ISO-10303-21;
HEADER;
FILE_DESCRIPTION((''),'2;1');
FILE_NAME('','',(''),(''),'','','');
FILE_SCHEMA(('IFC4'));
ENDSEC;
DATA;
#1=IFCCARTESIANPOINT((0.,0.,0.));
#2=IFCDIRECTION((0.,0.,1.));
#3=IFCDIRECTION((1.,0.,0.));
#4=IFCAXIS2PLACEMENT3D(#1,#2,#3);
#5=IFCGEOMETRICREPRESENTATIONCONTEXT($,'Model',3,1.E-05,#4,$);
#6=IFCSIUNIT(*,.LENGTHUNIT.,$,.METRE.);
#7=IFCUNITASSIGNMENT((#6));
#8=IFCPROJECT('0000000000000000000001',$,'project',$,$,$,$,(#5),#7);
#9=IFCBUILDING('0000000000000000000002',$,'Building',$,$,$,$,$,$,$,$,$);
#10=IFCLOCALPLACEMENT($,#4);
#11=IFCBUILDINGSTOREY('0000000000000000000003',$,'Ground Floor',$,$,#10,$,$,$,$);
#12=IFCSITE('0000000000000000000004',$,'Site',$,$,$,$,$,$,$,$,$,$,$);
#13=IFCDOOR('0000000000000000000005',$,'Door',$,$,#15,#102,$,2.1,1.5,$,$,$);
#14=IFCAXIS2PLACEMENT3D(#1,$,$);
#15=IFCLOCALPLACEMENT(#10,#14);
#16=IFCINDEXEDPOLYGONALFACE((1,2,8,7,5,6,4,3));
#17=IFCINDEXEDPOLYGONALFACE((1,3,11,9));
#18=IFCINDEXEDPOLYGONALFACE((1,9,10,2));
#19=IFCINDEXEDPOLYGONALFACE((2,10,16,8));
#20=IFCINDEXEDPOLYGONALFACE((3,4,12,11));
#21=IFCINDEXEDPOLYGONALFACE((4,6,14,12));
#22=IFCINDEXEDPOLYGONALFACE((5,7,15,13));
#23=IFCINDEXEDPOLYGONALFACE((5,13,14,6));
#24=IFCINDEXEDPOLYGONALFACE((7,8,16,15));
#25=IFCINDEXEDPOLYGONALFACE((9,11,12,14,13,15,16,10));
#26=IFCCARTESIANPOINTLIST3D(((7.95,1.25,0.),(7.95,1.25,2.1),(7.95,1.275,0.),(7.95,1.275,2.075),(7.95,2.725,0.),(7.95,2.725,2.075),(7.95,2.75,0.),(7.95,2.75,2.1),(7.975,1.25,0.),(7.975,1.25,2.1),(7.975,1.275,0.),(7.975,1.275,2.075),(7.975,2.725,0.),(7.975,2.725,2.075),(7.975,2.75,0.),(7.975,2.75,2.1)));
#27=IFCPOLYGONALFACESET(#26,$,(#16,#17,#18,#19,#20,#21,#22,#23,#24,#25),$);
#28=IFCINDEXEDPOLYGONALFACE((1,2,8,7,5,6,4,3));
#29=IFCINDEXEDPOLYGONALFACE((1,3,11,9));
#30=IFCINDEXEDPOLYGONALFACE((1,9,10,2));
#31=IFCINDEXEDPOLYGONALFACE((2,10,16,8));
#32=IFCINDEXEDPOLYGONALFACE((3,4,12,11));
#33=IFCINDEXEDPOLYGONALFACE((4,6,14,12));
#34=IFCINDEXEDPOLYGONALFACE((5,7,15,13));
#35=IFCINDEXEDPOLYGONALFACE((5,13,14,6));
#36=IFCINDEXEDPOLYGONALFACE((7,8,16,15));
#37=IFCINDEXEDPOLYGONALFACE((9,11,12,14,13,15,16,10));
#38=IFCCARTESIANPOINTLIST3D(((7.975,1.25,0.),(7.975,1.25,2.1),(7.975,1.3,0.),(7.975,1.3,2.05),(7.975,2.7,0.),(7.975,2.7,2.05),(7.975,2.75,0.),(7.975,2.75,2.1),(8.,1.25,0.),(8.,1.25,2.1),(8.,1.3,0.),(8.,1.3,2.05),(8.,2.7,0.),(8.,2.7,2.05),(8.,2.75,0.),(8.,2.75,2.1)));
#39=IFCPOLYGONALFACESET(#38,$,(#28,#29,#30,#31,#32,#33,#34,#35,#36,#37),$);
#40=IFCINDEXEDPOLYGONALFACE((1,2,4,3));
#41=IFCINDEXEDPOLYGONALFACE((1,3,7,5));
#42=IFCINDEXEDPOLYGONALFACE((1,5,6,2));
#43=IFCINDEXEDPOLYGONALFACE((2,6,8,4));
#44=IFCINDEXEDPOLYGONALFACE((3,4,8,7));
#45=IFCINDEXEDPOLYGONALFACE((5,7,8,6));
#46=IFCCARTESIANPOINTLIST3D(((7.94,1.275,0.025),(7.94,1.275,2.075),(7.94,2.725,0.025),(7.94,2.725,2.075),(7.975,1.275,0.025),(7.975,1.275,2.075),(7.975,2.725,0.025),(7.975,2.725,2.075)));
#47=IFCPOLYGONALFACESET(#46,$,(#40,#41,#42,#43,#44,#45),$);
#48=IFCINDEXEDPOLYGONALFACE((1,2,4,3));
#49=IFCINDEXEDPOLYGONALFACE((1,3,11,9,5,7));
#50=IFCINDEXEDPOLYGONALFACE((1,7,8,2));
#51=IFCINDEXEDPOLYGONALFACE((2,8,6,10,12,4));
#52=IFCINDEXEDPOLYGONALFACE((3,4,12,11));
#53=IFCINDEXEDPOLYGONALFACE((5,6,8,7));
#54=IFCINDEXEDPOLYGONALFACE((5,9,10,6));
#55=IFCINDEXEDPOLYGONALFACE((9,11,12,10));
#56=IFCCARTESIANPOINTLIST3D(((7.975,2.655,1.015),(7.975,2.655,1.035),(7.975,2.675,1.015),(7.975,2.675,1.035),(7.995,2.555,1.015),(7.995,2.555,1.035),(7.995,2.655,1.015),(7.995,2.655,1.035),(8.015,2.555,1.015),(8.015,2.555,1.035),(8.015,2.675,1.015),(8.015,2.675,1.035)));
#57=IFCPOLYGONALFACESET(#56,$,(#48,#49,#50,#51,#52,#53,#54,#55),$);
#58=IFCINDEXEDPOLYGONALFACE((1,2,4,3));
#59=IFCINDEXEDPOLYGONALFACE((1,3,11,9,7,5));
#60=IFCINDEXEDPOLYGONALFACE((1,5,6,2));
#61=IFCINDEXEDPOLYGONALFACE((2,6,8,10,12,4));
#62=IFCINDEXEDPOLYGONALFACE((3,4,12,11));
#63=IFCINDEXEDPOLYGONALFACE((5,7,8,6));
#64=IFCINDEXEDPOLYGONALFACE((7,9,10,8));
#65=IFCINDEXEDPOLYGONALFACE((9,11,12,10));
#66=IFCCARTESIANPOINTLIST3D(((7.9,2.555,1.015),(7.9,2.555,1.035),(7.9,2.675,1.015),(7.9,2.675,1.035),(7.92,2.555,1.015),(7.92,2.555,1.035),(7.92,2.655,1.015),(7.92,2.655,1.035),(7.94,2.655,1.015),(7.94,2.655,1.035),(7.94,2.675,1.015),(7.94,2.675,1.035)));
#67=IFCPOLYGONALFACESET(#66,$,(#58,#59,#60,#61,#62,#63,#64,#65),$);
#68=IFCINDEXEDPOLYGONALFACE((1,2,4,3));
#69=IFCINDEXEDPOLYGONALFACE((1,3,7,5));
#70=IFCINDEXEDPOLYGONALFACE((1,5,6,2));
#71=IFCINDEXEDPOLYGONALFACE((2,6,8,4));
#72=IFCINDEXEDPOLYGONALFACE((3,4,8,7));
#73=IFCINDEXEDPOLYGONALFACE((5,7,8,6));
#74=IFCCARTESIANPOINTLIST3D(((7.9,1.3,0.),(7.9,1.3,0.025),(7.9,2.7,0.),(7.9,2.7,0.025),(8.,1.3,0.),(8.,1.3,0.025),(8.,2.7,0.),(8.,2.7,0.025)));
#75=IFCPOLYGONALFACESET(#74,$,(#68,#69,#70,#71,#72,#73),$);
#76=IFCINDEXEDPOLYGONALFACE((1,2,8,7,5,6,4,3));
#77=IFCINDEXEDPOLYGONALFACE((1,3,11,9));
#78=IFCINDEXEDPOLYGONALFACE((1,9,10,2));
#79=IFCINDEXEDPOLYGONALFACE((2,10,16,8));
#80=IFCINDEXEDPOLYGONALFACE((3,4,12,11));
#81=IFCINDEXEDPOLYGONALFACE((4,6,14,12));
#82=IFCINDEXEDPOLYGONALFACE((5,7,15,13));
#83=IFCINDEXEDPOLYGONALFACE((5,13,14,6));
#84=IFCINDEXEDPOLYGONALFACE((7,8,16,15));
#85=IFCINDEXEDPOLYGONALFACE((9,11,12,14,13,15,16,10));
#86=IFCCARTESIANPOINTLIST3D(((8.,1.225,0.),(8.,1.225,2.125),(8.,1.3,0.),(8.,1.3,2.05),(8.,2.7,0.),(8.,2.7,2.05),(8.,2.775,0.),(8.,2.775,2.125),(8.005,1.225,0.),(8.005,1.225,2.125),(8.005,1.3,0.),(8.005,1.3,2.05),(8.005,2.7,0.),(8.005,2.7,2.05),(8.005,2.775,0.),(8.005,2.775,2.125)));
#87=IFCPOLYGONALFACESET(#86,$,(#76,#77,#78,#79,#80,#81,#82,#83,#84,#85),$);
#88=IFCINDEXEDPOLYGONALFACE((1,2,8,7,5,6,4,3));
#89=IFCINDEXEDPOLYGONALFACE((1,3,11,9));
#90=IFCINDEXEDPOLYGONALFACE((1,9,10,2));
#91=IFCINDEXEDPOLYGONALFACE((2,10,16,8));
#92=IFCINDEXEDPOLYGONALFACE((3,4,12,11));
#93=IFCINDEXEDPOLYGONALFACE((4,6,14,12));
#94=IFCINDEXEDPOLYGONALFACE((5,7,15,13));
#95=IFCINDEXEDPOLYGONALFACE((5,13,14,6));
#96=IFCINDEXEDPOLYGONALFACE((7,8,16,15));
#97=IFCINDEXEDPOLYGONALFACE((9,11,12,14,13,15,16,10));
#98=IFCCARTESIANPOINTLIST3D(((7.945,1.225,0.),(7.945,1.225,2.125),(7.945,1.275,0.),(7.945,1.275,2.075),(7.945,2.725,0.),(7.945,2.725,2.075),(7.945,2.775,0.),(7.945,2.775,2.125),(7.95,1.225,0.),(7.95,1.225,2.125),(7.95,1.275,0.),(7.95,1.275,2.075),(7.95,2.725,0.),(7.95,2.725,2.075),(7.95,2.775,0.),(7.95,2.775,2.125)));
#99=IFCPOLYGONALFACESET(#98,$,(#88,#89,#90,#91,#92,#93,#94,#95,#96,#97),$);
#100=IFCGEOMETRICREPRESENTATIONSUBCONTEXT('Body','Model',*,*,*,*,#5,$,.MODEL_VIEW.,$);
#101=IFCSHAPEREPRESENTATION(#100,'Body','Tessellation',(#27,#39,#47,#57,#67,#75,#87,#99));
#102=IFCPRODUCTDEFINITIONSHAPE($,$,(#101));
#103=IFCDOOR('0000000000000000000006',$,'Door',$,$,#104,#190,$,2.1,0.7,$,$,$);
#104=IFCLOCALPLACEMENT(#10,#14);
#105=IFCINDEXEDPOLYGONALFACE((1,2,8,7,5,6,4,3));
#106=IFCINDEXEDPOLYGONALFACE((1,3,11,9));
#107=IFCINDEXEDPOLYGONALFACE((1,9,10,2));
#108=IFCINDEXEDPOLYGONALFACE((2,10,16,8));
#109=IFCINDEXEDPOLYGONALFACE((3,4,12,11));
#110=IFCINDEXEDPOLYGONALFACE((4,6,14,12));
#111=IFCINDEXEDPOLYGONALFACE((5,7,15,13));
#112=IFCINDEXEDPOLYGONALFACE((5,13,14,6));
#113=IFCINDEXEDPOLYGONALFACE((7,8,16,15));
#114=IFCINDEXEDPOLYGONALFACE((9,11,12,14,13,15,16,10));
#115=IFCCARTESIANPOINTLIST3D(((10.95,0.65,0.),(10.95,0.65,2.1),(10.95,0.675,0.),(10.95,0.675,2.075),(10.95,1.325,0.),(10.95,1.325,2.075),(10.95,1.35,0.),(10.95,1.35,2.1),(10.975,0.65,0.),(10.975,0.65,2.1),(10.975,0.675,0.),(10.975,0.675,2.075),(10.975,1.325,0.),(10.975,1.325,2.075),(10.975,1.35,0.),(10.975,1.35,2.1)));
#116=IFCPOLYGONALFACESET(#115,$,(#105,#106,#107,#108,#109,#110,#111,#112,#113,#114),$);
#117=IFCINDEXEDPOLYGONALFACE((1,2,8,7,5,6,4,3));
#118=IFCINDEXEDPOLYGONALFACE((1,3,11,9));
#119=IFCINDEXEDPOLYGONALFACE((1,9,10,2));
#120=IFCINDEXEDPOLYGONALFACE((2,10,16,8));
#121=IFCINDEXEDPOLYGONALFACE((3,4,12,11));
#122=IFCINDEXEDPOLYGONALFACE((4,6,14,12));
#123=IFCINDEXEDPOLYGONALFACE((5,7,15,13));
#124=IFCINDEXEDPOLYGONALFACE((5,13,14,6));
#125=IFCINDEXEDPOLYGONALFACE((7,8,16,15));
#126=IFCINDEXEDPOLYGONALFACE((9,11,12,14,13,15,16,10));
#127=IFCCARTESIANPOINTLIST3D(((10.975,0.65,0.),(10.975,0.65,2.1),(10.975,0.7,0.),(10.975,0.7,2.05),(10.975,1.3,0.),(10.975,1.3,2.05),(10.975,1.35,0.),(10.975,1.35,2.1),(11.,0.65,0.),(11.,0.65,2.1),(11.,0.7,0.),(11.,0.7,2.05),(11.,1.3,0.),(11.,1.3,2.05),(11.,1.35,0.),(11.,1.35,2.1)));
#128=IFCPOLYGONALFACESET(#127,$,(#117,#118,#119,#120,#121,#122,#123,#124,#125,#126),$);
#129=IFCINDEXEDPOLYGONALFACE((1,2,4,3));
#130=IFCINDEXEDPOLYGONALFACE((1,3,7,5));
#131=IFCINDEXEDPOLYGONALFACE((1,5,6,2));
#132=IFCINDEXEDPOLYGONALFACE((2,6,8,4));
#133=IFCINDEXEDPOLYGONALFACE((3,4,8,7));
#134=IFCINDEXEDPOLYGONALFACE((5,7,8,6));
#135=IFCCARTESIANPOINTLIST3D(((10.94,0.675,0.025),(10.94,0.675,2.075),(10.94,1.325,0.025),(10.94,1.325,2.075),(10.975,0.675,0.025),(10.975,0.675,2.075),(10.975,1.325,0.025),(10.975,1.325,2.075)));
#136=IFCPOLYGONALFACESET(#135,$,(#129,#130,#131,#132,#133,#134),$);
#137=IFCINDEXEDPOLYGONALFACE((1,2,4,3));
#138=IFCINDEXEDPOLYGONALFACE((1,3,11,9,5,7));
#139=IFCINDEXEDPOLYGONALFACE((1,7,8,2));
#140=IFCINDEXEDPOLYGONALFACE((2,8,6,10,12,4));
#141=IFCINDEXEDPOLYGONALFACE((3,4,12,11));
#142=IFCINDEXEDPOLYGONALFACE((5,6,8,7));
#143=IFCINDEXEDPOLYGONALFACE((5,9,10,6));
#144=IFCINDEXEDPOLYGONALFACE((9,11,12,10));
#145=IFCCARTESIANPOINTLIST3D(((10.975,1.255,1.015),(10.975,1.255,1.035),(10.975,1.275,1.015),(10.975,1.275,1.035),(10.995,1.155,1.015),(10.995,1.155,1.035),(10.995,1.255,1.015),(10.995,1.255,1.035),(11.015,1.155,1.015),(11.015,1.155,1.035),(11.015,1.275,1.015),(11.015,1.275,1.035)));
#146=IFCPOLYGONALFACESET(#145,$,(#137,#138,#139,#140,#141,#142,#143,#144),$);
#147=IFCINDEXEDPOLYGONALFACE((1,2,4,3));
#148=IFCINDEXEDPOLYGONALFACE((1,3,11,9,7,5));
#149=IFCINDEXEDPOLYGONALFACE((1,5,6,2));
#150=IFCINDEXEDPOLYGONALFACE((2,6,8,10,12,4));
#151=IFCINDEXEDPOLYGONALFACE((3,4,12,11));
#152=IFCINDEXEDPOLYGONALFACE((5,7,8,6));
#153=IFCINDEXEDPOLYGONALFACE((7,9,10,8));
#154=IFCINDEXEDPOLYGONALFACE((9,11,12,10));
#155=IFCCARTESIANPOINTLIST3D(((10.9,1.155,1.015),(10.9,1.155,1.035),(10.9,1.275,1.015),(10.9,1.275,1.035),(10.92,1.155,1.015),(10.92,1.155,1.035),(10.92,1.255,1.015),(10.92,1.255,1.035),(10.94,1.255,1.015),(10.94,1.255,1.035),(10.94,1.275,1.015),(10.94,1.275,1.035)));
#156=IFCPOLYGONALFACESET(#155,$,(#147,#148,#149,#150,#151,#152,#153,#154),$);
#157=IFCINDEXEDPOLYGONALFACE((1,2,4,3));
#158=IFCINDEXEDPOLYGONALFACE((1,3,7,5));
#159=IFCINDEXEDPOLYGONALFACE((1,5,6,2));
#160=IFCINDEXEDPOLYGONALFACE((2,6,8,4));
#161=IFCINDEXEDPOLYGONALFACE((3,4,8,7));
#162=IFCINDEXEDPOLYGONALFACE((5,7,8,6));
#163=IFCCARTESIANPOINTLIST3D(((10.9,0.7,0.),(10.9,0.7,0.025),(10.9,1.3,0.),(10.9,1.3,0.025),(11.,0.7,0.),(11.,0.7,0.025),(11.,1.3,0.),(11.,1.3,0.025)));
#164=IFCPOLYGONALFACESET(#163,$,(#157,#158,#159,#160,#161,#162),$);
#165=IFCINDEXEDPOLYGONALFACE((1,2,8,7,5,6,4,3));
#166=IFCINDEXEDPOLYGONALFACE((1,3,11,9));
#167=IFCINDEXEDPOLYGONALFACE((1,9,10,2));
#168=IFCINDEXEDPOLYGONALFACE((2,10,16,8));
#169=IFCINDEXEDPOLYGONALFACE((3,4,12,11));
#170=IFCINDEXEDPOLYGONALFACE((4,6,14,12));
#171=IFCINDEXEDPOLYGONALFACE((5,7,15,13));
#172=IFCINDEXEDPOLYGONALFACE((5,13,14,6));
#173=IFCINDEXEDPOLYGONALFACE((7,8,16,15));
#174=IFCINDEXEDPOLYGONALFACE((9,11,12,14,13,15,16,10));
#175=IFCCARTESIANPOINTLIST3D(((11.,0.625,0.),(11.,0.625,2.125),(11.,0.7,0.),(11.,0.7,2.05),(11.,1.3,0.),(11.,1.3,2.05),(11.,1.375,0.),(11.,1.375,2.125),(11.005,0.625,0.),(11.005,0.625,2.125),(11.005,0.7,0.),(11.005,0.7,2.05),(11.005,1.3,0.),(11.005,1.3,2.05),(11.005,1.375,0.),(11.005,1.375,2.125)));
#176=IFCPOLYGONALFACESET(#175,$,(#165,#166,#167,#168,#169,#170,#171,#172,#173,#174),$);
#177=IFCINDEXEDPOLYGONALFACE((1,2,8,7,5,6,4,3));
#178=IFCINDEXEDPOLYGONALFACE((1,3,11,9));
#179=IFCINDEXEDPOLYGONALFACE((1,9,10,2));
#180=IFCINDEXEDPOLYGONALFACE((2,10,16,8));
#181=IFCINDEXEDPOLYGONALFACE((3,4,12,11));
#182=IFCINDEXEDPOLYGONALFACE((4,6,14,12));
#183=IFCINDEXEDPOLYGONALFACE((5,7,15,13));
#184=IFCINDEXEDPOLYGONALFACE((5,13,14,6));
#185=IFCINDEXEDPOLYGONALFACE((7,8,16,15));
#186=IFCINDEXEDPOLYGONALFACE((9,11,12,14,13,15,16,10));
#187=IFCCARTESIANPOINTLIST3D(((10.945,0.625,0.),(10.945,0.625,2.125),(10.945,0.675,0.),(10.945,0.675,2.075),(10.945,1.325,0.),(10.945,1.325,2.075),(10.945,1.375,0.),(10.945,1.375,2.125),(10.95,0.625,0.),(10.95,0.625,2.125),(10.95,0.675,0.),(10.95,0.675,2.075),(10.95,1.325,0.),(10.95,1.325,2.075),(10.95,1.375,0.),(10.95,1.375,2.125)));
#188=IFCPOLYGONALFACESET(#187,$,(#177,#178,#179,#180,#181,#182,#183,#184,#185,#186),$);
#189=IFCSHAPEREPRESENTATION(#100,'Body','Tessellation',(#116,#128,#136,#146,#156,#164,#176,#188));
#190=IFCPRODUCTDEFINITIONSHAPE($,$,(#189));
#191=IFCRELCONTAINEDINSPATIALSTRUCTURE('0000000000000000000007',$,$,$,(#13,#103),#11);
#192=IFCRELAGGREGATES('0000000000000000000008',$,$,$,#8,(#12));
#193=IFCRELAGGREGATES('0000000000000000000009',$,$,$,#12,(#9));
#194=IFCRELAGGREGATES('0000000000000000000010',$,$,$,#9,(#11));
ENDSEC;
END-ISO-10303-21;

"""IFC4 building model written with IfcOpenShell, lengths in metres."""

from ifc_helpers import new_model, si_unit, frame, origin_with_axes, place, context, subcontext, project, spatial, line, indexed_curve, outline, extrude, element, save


model = new_model("IFC4")

# Units and contexts
model_context = context("Model", 3, precision=1e-05, world=origin_with_axes())
body_context = subcontext(model_context, "Body", "Model", "MODEL_VIEW")
ifc_project = project(units=[si_unit("LENGTHUNIT", "METRE")], contexts=[model_context])

# Site, building, storey
site = spatial("IfcSite", under=ifc_project, Name="Site")
building = spatial("IfcBuilding", under=site, Name="Building")
storey_placement = place(None, origin_with_axes())
storey = spatial("IfcBuildingStorey", under=building, at=storey_placement, Name="Ground Floor")

# Doors
door_1_placement = place(storey_placement, frame((8.0, 1.25, 0.0), z_axis=(0.0, 0.0, 1.0), x_axis=(0.0, 1.0, 0.0)))
element("IfcDoor", 1, at=door_1_placement, inside=storey, Name="Door", OverallHeight=2.1, OverallWidth=1.5, context=body_context, shape_type="SweptSolid", body=[
    extrude(outline(indexed_curve([(0.0, 0.0), (0.0, 2.1), (1.5, 2.1), (1.5, 0.0), (1.475, 0.0), (1.475, 2.075), (0.025, 2.075), (0.025, 0.0)], segments=[line(1, 2, 3, 4, 5, 6, 7, 8, 1)])), frame((0.0, 0.025, 0.0), z_axis=(0.0, -1.0, 0.0), x_axis=(1.0, 0.0, 0.0)), (0.0, 0.0, -1.0), 0.025),
    extrude(outline(indexed_curve([(0.0, 0.0), (0.0, 2.1), (1.5, 2.1), (1.5, 0.0), (1.45, 0.0), (1.45, 2.05), (0.05, 2.05), (0.05, 0.0)], segments=[line(1, 2, 3, 4, 5, 6, 7, 8, 1)])), frame((0.0, 0.0, 0.0), z_axis=(0.0, -1.0, 0.0), x_axis=(1.0, 0.0, 0.0)), (0.0, 0.0, -1.0), 0.025),
    extrude(outline(indexed_curve([(0.0, 0.0), (1.45, 0.0), (1.45, 0.035), (0.0, 0.035)], segments=[line(1, 2, 3, 4, 1)])), frame((0.025, 0.025, 0.025), z_axis=(0.0, 0.0, 1.0), x_axis=(1.0, 0.0, 0.0)), (0.0, 0.0, 1.0), 2.05),
    extrude(outline(indexed_curve([(0.0, 0.0), (0.0, -0.04), (-0.12, -0.04), (-0.12, -0.02), (-0.02, -0.02), (-0.02, 0.0)], segments=[line(1, 2, 3, 4, 5, 6, 1)])), frame((1.425, 0.025, 1.015), z_axis=(0.0, 0.0, 1.0), x_axis=(1.0, 0.0, 0.0)), (0.0, 0.0, 1.0), 0.02),
    extrude(outline(indexed_curve([(0.0, 0.0), (0.0, 0.04), (-0.12, 0.04), (-0.12, 0.02), (-0.02, 0.02), (-0.02, 0.0)], segments=[line(1, 2, 3, 4, 5, 6, 1)])), frame((1.425, 0.06, 1.015), z_axis=(0.0, 0.0, 1.0), x_axis=(1.0, 0.0, 0.0)), (0.0, 0.0, 1.0), 0.02),
    extrude(outline(indexed_curve([(0.0, 0.0), (1.4, 0.0), (1.4, 0.1), (0.0, 0.1)], segments=[line(1, 2, 3, 4, 1)])), frame((0.05, 0.0, 0.0), z_axis=(0.0, 0.0, 1.0), x_axis=(1.0, 0.0, 0.0)), (0.0, 0.0, 1.0), 0.025),
    extrude(outline(indexed_curve([(0.0, 0.0), (0.0, 2.125), (1.55, 2.125), (1.55, 0.0), (1.475, 0.0), (1.475, 2.05), (0.075, 2.05), (0.075, 0.0)], segments=[line(1, 2, 3, 4, 5, 6, 7, 8, 1)])), frame((-0.025, -0.005, 0.0), z_axis=(0.0, -1.0, 0.0), x_axis=(1.0, 0.0, 0.0)), (0.0, 0.0, -1.0), 0.005),
    extrude(outline(indexed_curve([(0.0, 0.0), (0.0, 2.125), (1.55, 2.125), (1.55, 0.0), (1.5, 0.0), (1.5, 2.075), (0.05, 2.075), (0.05, 0.0)], segments=[line(1, 2, 3, 4, 5, 6, 7, 8, 1)])), frame((-0.025, 0.05, 0.0), z_axis=(0.0, -1.0, 0.0), x_axis=(1.0, 0.0, 0.0)), (0.0, 0.0, -1.0), 0.005),
])
door_2_placement = place(storey_placement, frame((11.0, 0.65, 0.0), z_axis=(0.0, 0.0, 1.0), x_axis=(0.0, 1.0, 0.0)))
element("IfcDoor", 2, at=door_2_placement, inside=storey, Name="Door", OverallHeight=2.1, OverallWidth=0.7, context=body_context, shape_type="SweptSolid", body=[
    extrude(outline(indexed_curve([(0.0, 0.0), (0.0, 2.1), (0.7, 2.1), (0.7, 0.0), (0.675, 0.0), (0.675, 2.075), (0.025, 2.075), (0.025, 0.0)], segments=[line(1, 2, 3, 4, 5, 6, 7, 8, 1)])), frame((0.0, 0.025, 0.0), z_axis=(0.0, -1.0, 0.0), x_axis=(1.0, 0.0, 0.0)), (0.0, 0.0, -1.0), 0.025),
    extrude(outline(indexed_curve([(0.0, 0.0), (0.0, 2.1), (0.7, 2.1), (0.7, 0.0), (0.65, 0.0), (0.65, 2.05), (0.05, 2.05), (0.05, 0.0)], segments=[line(1, 2, 3, 4, 5, 6, 7, 8, 1)])), frame((0.0, 0.0, 0.0), z_axis=(0.0, -1.0, 0.0), x_axis=(1.0, 0.0, 0.0)), (0.0, 0.0, -1.0), 0.025),
    extrude(outline(indexed_curve([(0.0, 0.0), (0.65, 0.0), (0.65, 0.035), (0.0, 0.035)], segments=[line(1, 2, 3, 4, 1)])), frame((0.025, 0.025, 0.025), z_axis=(0.0, 0.0, 1.0), x_axis=(1.0, 0.0, 0.0)), (0.0, 0.0, 1.0), 2.05),
    extrude(outline(indexed_curve([(0.0, 0.0), (0.0, -0.04), (-0.12, -0.04), (-0.12, -0.02), (-0.02, -0.02), (-0.02, 0.0)], segments=[line(1, 2, 3, 4, 5, 6, 1)])), frame((0.625, 0.025, 1.015), z_axis=(0.0, 0.0, 1.0), x_axis=(1.0, 0.0, 0.0)), (0.0, 0.0, 1.0), 0.02),
    extrude(outline(indexed_curve([(0.0, 0.0), (0.0, 0.04), (-0.12, 0.04), (-0.12, 0.02), (-0.02, 0.02), (-0.02, 0.0)], segments=[line(1, 2, 3, 4, 5, 6, 1)])), frame((0.625, 0.06, 1.015), z_axis=(0.0, 0.0, 1.0), x_axis=(1.0, 0.0, 0.0)), (0.0, 0.0, 1.0), 0.02),
    extrude(outline(indexed_curve([(0.0, 0.0), (0.6, 0.0), (0.6, 0.1), (0.0, 0.1)], segments=[line(1, 2, 3, 4, 1)])), frame((0.05, 0.0, 0.0), z_axis=(0.0, 0.0, 1.0), x_axis=(1.0, 0.0, 0.0)), (0.0, 0.0, 1.0), 0.025),
    extrude(outline(indexed_curve([(0.0, 0.0), (0.0, 2.125), (0.75, 2.125), (0.75, 0.0), (0.675, 0.0), (0.675, 2.05), (0.075, 2.05), (0.075, 0.0)], segments=[line(1, 2, 3, 4, 5, 6, 7, 8, 1)])), frame((-0.025, -0.005, 0.0), z_axis=(0.0, -1.0, 0.0), x_axis=(1.0, 0.0, 0.0)), (0.0, 0.0, -1.0), 0.005),
    extrude(outline(indexed_curve([(0.0, 0.0), (0.0, 2.125), (0.75, 2.125), (0.75, 0.0), (0.7, 0.0), (0.7, 2.075), (0.05, 2.075), (0.05, 0.0)], segments=[line(1, 2, 3, 4, 5, 6, 7, 8, 1)])), frame((-0.025, 0.05, 0.0), z_axis=(0.0, -1.0, 0.0), x_axis=(1.0, 0.0, 0.0)), (0.0, 0.0, -1.0), 0.005),
])

save(model, "model.ifc")
